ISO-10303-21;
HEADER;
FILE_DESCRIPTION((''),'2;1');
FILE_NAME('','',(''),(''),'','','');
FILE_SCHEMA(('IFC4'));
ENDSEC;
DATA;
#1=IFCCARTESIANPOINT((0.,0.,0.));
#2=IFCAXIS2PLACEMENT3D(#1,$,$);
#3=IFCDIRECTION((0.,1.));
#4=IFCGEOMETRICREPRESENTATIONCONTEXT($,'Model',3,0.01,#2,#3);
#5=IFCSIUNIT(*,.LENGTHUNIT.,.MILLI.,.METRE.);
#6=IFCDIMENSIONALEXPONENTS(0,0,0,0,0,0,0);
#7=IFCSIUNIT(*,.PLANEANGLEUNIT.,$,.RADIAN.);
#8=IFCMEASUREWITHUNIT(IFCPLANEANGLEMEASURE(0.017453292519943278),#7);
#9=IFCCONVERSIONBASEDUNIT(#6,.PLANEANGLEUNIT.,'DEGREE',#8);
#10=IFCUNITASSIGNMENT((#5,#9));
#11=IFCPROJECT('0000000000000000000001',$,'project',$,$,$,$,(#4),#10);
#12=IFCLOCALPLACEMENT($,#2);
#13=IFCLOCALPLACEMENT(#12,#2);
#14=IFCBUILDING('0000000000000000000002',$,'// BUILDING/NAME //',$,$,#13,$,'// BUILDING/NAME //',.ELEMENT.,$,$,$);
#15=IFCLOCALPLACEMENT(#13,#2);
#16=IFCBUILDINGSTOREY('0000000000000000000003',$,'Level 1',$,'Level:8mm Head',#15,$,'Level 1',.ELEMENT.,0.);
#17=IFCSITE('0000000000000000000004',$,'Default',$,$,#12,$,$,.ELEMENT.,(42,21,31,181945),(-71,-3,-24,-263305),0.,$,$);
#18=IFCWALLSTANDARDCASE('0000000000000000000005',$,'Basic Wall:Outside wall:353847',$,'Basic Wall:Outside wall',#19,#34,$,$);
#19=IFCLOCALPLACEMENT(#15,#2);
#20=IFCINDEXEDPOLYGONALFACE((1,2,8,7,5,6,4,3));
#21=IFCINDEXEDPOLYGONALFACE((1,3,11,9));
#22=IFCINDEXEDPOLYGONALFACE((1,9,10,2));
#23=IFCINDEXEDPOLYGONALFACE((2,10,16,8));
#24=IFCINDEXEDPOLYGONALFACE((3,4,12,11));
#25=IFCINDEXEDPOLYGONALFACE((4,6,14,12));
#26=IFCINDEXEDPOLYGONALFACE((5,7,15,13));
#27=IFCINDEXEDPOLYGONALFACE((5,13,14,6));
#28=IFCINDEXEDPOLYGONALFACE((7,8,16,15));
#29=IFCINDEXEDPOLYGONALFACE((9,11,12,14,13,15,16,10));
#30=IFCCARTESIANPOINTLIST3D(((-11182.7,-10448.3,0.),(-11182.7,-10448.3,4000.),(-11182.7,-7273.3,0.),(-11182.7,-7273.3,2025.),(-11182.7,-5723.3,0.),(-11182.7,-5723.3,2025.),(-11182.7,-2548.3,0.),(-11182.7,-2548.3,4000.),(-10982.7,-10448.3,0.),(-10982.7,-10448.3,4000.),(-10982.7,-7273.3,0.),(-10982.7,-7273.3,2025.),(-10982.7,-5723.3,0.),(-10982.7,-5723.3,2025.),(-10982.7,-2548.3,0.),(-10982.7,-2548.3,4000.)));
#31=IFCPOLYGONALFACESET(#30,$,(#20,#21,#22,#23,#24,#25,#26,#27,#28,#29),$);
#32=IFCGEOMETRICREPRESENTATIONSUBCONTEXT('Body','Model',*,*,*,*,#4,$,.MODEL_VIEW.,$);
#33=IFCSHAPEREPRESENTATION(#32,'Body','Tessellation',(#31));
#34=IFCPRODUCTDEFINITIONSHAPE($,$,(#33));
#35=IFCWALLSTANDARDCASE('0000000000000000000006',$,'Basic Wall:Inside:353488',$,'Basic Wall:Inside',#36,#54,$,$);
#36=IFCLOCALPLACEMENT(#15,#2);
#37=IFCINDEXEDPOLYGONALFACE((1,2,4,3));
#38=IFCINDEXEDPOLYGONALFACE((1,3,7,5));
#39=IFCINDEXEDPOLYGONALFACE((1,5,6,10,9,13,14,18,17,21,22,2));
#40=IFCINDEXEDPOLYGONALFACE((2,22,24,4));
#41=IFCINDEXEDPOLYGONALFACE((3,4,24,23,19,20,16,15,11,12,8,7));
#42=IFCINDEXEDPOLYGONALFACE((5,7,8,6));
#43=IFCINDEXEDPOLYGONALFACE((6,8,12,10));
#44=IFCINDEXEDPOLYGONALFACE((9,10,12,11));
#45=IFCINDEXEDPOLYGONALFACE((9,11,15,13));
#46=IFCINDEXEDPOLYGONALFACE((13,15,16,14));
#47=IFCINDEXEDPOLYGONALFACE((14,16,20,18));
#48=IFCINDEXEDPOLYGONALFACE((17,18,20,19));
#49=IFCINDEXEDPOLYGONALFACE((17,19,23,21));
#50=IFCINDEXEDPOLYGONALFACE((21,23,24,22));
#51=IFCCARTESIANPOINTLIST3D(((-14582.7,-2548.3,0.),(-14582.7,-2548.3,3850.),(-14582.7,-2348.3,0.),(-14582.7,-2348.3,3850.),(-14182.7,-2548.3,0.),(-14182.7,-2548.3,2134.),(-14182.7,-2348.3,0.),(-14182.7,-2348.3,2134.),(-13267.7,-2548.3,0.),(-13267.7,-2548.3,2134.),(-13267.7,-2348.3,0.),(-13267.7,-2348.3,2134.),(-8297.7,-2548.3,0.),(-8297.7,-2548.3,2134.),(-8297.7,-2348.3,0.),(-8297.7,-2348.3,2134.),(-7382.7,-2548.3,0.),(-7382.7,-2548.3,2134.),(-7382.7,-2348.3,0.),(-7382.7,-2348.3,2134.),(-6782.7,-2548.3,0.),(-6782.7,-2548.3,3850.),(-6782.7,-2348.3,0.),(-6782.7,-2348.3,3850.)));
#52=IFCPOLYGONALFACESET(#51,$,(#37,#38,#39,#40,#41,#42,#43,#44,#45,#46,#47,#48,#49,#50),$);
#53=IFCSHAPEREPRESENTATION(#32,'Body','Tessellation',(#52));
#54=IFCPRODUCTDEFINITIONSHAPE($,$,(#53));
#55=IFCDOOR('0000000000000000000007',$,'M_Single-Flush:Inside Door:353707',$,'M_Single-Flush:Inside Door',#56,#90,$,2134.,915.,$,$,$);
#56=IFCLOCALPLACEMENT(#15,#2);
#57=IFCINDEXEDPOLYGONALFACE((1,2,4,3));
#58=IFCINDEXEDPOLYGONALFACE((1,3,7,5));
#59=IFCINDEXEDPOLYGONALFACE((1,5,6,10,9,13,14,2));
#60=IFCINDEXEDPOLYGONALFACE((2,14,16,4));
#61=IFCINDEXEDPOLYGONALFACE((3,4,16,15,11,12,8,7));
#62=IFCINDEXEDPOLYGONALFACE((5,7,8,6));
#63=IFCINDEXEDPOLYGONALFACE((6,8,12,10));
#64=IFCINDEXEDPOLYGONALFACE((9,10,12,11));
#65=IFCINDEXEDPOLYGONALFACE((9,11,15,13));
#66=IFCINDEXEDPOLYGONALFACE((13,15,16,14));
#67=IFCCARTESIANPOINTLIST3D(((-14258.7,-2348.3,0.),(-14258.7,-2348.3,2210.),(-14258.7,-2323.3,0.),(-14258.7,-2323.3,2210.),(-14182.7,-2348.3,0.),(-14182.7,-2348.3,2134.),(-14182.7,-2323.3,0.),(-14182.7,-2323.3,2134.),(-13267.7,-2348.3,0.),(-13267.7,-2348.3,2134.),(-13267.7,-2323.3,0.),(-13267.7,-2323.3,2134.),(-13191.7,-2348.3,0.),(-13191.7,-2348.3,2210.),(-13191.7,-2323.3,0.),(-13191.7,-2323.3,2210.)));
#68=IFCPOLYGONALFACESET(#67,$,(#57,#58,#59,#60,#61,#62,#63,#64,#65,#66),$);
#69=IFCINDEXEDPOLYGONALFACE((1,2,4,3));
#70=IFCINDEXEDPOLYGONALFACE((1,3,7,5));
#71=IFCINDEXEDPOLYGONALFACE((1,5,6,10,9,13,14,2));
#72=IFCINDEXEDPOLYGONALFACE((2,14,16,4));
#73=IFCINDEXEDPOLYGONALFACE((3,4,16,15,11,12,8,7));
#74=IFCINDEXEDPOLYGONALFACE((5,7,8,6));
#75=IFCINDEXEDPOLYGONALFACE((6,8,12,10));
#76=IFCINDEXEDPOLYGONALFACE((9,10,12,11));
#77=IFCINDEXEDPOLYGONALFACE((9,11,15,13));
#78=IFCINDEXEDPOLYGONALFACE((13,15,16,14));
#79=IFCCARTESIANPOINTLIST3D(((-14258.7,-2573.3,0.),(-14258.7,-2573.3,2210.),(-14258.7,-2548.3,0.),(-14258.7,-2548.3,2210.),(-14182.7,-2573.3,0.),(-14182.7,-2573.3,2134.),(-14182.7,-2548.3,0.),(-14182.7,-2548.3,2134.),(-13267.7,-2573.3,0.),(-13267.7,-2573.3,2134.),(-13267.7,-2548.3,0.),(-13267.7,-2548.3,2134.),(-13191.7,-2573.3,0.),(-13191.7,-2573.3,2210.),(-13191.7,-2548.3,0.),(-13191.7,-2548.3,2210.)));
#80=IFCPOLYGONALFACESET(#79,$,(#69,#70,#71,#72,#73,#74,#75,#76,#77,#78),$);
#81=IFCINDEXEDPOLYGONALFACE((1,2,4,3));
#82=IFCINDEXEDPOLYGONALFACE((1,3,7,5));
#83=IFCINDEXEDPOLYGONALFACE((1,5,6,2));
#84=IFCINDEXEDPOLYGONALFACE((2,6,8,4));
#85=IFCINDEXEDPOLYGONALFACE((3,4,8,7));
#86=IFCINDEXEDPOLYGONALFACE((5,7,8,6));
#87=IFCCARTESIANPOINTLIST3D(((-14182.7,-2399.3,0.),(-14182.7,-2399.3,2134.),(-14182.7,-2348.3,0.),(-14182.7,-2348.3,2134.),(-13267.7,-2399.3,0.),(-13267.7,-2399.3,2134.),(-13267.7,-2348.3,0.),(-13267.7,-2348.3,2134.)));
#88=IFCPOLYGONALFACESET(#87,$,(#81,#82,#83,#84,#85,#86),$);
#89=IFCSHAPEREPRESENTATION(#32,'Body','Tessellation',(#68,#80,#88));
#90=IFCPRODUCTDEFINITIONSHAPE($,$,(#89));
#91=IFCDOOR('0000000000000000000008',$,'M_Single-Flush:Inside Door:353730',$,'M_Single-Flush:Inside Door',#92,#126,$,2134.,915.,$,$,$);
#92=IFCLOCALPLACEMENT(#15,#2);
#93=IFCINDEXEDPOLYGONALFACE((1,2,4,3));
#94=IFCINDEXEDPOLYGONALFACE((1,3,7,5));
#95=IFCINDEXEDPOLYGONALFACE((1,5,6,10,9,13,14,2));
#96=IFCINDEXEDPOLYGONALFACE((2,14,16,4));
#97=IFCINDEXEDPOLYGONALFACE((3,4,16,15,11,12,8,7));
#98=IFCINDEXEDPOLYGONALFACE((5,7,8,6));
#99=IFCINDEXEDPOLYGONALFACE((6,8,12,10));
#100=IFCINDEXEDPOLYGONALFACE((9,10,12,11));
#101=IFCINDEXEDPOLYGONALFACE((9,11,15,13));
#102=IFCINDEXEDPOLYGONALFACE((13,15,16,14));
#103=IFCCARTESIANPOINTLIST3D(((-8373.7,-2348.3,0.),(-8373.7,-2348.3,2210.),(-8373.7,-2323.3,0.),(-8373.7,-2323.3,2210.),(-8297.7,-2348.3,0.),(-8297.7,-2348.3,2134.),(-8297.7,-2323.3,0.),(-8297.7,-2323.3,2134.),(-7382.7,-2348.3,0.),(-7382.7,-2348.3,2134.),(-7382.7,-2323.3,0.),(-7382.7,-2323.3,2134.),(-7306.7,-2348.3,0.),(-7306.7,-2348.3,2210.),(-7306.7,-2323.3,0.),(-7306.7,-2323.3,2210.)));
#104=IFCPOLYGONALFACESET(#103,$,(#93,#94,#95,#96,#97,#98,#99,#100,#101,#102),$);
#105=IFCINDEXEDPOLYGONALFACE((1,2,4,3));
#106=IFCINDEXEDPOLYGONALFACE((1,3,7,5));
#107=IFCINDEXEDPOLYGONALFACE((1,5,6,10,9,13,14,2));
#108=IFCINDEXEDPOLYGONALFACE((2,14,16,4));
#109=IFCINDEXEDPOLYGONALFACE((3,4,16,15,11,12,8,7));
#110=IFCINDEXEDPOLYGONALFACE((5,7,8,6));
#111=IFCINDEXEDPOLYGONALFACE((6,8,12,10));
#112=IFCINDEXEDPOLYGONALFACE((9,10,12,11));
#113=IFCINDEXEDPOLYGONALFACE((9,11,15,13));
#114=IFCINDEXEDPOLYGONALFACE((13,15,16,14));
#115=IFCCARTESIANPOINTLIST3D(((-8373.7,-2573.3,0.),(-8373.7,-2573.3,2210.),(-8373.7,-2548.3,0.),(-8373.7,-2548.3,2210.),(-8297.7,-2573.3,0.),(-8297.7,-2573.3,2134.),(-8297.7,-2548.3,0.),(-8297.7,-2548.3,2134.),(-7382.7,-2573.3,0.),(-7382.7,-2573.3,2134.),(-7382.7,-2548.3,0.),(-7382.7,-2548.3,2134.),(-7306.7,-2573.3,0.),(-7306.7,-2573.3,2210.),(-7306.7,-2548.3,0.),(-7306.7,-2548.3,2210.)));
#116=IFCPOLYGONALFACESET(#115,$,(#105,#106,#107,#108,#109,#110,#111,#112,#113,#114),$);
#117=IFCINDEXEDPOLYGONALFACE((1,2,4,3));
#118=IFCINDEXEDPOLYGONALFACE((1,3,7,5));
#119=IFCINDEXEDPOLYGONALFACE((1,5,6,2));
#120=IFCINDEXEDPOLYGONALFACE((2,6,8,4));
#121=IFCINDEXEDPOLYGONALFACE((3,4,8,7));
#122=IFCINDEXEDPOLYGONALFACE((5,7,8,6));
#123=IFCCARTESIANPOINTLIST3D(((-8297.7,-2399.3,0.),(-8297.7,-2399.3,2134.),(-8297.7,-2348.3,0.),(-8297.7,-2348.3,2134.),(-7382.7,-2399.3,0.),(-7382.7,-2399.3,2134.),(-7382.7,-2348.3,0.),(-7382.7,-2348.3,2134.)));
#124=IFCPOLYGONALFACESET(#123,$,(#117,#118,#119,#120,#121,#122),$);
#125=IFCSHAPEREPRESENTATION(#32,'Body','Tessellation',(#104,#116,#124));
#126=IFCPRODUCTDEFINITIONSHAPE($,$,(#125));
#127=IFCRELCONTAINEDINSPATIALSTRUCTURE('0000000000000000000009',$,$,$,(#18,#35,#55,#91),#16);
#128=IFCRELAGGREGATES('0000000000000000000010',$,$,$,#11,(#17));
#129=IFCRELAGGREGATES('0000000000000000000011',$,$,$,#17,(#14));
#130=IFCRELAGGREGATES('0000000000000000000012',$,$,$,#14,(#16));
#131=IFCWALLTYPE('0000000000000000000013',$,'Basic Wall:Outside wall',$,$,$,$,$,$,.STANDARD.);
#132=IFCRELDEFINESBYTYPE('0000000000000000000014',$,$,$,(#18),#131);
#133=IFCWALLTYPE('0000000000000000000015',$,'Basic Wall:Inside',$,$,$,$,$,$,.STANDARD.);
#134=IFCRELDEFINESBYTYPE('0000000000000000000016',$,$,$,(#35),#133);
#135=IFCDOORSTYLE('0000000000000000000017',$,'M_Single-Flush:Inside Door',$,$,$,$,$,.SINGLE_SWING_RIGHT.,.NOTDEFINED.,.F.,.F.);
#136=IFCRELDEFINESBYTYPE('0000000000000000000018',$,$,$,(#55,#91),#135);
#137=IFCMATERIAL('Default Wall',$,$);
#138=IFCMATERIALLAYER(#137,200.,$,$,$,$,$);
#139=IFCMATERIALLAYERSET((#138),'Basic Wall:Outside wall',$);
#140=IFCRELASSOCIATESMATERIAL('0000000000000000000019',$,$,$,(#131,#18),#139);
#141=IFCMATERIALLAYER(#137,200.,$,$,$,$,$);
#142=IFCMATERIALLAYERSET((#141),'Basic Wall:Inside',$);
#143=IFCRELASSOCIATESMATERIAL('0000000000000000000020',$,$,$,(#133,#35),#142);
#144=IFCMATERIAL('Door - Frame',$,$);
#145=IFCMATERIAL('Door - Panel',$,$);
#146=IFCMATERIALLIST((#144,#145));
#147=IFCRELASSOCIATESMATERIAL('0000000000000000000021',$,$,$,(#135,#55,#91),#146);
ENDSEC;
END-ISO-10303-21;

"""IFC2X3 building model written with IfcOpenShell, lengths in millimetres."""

from ifc_helpers import new_model, entity, si_unit, converted_unit, direction, frame, frame_2d, origin, place, context, subcontext, project, spatial, polyline, rectangle, outline, extrude, clip, bounded_halfspace, source, transform, mapped, material, material_list, layer, layer_set, layer_usage, type_object, type_shapes, element, fill, save


model = new_model("IFC2X3")

# Units and contexts
model_context = context("Model", 3, precision=0.01, world=origin(), true_north=direction((0.0, 1.0)))
body_context = subcontext(model_context, "Body", "Model", "MODEL_VIEW")
ifc_project = project(units=[si_unit("LENGTHUNIT", "METRE", prefix="MILLI"), converted_unit("PLANEANGLEUNIT", "DEGREE", entity("IfcPlaneAngleMeasure", 0.017453292519943278), si_unit("PLANEANGLEUNIT", "RADIAN"), dimensions=[0, 0, 0, 0, 0, 0, 0])], contexts=[model_context])

# Site, building, storey
site_placement = place(None, origin())
site = spatial("IfcSite", under=ifc_project, at=site_placement, Name="Default", CompositionType="ELEMENT", RefLatitude=(42, 21, 31, 181945), RefLongitude=(-71, -3, -24, -263305), RefElevation=0.0)
building_placement = place(site_placement, origin())
building = spatial("IfcBuilding", under=site, at=building_placement, Name="// BUILDING/NAME //", LongName="// BUILDING/NAME //", CompositionType="ELEMENT")
storey_placement = place(building_placement, origin())
storey = spatial("IfcBuildingStorey", under=building, at=storey_placement, Name="Level 1", ObjectType="Level:8mm Head", LongName="Level 1", CompositionType="ELEMENT", Elevation=0.0)

# Shared definitions
ifc_material_1 = material(Name="Default Wall")
ifc_layer_1 = layer(ifc_material_1, 200.0)
ifc_layer_set_1 = layer_set([ifc_layer_1], Name="Basic Wall:Outside wall")
ifc_layer_usage_1 = layer_usage(ifc_layer_set_1, "AXIS2", "NEGATIVE", 100.0)
wall_type_1 = type_object("IfcWallType", Name="Basic Wall:Outside wall", PredefinedType="STANDARD", material=ifc_layer_set_1)
ifc_material_2 = material(Name="Door - Frame")
ifc_material_3 = material(Name="Door - Panel")
ifc_material_list_1 = material_list([ifc_material_2, ifc_material_3])

# Wall, opening
wall_1_placement = place(storey_placement, frame((-11082.7, -2548.3, 0.0), z_axis=(0.0, 0.0, 1.0), x_axis=(0.0, -1.0, 0.0)))
wall_1 = element("IfcWallStandardCase", 1, at=wall_1_placement, inside=storey, type_object=wall_type_1, material=ifc_layer_usage_1, Name="Basic Wall:Outside wall:353847", ObjectType="Basic Wall:Outside wall", context=body_context, shape_type="SweptSolid", body=[
    extrude(rectangle(XDim=7900.0, YDim=200.0, at=frame_2d((3950.0, 0.0), x_axis=(1.0, 0.0))), origin(), (0.0, 0.0, 1.0), 4000.0),
])
opening_1_placement = place(wall_1_placement, frame((4725.0, 100.0, 0.0)))
element("IfcOpeningElement", 2, at=opening_1_placement, cuts=wall_1, ObjectType="Opening", context=body_context, shape_type="SweptSolid", body=[
    extrude(rectangle(XDim=2025.0, YDim=1550.0, at=frame_2d((1012.5, 775.0), x_axis=(1.0, 0.0))), frame((0.0, 0.0, 0.0), z_axis=(0.0, -1.0, 0.0), x_axis=(0.0, 0.0, 1.0)), (0.0, 0.0, 1.0), 200.0),
])

# Wall, openings, doors
ifc_layer_2 = layer(ifc_material_1, 200.0)
ifc_layer_set_2 = layer_set([ifc_layer_2], Name="Basic Wall:Inside")
ifc_layer_usage_2 = layer_usage(ifc_layer_set_2, "AXIS2", "NEGATIVE", 100.0)
wall_type_2 = type_object("IfcWallType", Name="Basic Wall:Inside", PredefinedType="STANDARD", material=ifc_layer_set_2)
wall_2_placement = place(storey_placement, frame((-14582.7, -2448.3, 0.0)))
wall_2 = element("IfcWallStandardCase", 3, at=wall_2_placement, inside=storey, type_object=wall_type_2, material=ifc_layer_usage_2, Name="Basic Wall:Inside:353488", ObjectType="Basic Wall:Inside", context=body_context, shape_type="Clipping", body=[
    clip(extrude(rectangle(XDim=7800.0, YDim=200.0, at=frame_2d((3900.0, 0.0), x_axis=(-1.0, 0.0))), origin(), (0.0, 0.0, 1.0), 3850.0), bounded_halfspace(frame((0.0, -100.0, 3850.0), z_axis=(0.0, 0.0, -1.0), x_axis=(1.0, 0.0, 0.0)), True, frame((0.0, -100.0, 3850.0)), polyline([(0.0, 0.0), (7800.0, 0.0), (7800.0, 200.0), (0.0, 200.0), (0.0, 0.0)]))),
])
opening_2_placement = place(wall_2_placement, frame((400.0, -100.0, 0.0)))
opening_2 = element("IfcOpeningElement", 4, at=opening_2_placement, cuts=wall_2, ObjectType="Opening", context=body_context, shape_type="SweptSolid", body=[
    extrude(rectangle(XDim=915.0, YDim=2134.0, at=frame_2d((1067.0, 457.5), x_axis=(0.0, 1.0))), frame((0.0, 0.0, 0.0), z_axis=(0.0, 1.0, 0.0), x_axis=(0.0, 0.0, 1.0)), (0.0, 0.0, 1.0), 200.0),
])
opening_3_placement = place(wall_2_placement, frame((6285.0, -100.0, 0.0)))
opening_3 = element("IfcOpeningElement", 5, at=opening_3_placement, cuts=wall_2, ObjectType="Opening", context=body_context, shape_type="SweptSolid", body=[
    extrude(rectangle(XDim=915.0, YDim=2134.0, at=frame_2d((1067.0, 457.5), x_axis=(0.0, 1.0))), frame((0.0, 0.0, 0.0), z_axis=(0.0, 1.0, 0.0), x_axis=(0.0, 0.0, 1.0)), (0.0, 0.0, 1.0), 200.0),
])
door_style_1 = type_object("IfcDoorStyle", Name="M_Single-Flush:Inside Door", ConstructionType="NOTDEFINED", OperationType="SINGLE_SWING_RIGHT", ParameterTakesPrecedence=False, Sizeable=False, material=ifc_material_list_1)
shared_shape_1 = source(origin(), body_context, "Body", "SweptSolid", [
    extrude(outline(polyline([(-533.5, -1124.0), (533.5, -1124.0), (533.5, 1086.0), (457.5, 1086.0), (457.5, -1048.0), (-457.5, -1048.0), (-457.5, 1086.0), (-533.5, 1086.0), (-533.5, -1124.0)])), frame((457.5, 200.0, 1086.0), z_axis=(0.0, 1.0, 0.0), x_axis=(1.0, 0.0, 0.0)), (0.0, 0.0, 1.0), 25.0),
    extrude(outline(polyline([(-1124.0, -533.5), (1086.0, -533.5), (1086.0, -457.5), (-1048.0, -457.5), (-1048.0, 457.5), (1086.0, 457.5), (1086.0, 533.5), (-1124.0, 533.5), (-1124.0, -533.5)])), frame((457.5, -25.0, 1086.0), z_axis=(0.0, 1.0, 0.0), x_axis=(0.0, 0.0, -1.0)), (0.0, 0.0, 1.0), 25.0),
    extrude(rectangle(XDim=51.0, YDim=915.0, at=frame_2d((0.0, 0.0), x_axis=(1.0, 0.0))), frame((457.5, 174.5, 0.0), z_axis=(0.0, 0.0, 1.0), x_axis=(0.0, 1.0, 0.0)), (0.0, 0.0, 1.0), 2134.0),
])
type_shapes(door_style_1, [shared_shape_1])
door_1_placement = place(opening_2_placement, origin())
door_1 = element("IfcDoor", 6, at=door_1_placement, inside=storey, type_object=door_style_1, material=ifc_material_list_1, Name="M_Single-Flush:Inside Door:353707", ObjectType="M_Single-Flush:Inside Door", OverallHeight=2134.0, OverallWidth=915.0, context=body_context, shape_type="MappedRepresentation", body=[
    mapped(shared_shape_1, transform((0.0, 0.0, 0.0), scale=1.0)),
])
fill(opening_2, door_1)
door_2_placement = place(opening_3_placement, origin())
door_2 = element("IfcDoor", 7, at=door_2_placement, inside=storey, type_object=door_style_1, material=ifc_material_list_1, Name="M_Single-Flush:Inside Door:353730", ObjectType="M_Single-Flush:Inside Door", OverallHeight=2134.0, OverallWidth=915.0, context=body_context, shape_type="MappedRepresentation", body=[
    mapped(shared_shape_1, transform((0.0, 0.0, 0.0), scale=1.0)),
])
fill(opening_3, door_2)

save(model, "model.ifc")
